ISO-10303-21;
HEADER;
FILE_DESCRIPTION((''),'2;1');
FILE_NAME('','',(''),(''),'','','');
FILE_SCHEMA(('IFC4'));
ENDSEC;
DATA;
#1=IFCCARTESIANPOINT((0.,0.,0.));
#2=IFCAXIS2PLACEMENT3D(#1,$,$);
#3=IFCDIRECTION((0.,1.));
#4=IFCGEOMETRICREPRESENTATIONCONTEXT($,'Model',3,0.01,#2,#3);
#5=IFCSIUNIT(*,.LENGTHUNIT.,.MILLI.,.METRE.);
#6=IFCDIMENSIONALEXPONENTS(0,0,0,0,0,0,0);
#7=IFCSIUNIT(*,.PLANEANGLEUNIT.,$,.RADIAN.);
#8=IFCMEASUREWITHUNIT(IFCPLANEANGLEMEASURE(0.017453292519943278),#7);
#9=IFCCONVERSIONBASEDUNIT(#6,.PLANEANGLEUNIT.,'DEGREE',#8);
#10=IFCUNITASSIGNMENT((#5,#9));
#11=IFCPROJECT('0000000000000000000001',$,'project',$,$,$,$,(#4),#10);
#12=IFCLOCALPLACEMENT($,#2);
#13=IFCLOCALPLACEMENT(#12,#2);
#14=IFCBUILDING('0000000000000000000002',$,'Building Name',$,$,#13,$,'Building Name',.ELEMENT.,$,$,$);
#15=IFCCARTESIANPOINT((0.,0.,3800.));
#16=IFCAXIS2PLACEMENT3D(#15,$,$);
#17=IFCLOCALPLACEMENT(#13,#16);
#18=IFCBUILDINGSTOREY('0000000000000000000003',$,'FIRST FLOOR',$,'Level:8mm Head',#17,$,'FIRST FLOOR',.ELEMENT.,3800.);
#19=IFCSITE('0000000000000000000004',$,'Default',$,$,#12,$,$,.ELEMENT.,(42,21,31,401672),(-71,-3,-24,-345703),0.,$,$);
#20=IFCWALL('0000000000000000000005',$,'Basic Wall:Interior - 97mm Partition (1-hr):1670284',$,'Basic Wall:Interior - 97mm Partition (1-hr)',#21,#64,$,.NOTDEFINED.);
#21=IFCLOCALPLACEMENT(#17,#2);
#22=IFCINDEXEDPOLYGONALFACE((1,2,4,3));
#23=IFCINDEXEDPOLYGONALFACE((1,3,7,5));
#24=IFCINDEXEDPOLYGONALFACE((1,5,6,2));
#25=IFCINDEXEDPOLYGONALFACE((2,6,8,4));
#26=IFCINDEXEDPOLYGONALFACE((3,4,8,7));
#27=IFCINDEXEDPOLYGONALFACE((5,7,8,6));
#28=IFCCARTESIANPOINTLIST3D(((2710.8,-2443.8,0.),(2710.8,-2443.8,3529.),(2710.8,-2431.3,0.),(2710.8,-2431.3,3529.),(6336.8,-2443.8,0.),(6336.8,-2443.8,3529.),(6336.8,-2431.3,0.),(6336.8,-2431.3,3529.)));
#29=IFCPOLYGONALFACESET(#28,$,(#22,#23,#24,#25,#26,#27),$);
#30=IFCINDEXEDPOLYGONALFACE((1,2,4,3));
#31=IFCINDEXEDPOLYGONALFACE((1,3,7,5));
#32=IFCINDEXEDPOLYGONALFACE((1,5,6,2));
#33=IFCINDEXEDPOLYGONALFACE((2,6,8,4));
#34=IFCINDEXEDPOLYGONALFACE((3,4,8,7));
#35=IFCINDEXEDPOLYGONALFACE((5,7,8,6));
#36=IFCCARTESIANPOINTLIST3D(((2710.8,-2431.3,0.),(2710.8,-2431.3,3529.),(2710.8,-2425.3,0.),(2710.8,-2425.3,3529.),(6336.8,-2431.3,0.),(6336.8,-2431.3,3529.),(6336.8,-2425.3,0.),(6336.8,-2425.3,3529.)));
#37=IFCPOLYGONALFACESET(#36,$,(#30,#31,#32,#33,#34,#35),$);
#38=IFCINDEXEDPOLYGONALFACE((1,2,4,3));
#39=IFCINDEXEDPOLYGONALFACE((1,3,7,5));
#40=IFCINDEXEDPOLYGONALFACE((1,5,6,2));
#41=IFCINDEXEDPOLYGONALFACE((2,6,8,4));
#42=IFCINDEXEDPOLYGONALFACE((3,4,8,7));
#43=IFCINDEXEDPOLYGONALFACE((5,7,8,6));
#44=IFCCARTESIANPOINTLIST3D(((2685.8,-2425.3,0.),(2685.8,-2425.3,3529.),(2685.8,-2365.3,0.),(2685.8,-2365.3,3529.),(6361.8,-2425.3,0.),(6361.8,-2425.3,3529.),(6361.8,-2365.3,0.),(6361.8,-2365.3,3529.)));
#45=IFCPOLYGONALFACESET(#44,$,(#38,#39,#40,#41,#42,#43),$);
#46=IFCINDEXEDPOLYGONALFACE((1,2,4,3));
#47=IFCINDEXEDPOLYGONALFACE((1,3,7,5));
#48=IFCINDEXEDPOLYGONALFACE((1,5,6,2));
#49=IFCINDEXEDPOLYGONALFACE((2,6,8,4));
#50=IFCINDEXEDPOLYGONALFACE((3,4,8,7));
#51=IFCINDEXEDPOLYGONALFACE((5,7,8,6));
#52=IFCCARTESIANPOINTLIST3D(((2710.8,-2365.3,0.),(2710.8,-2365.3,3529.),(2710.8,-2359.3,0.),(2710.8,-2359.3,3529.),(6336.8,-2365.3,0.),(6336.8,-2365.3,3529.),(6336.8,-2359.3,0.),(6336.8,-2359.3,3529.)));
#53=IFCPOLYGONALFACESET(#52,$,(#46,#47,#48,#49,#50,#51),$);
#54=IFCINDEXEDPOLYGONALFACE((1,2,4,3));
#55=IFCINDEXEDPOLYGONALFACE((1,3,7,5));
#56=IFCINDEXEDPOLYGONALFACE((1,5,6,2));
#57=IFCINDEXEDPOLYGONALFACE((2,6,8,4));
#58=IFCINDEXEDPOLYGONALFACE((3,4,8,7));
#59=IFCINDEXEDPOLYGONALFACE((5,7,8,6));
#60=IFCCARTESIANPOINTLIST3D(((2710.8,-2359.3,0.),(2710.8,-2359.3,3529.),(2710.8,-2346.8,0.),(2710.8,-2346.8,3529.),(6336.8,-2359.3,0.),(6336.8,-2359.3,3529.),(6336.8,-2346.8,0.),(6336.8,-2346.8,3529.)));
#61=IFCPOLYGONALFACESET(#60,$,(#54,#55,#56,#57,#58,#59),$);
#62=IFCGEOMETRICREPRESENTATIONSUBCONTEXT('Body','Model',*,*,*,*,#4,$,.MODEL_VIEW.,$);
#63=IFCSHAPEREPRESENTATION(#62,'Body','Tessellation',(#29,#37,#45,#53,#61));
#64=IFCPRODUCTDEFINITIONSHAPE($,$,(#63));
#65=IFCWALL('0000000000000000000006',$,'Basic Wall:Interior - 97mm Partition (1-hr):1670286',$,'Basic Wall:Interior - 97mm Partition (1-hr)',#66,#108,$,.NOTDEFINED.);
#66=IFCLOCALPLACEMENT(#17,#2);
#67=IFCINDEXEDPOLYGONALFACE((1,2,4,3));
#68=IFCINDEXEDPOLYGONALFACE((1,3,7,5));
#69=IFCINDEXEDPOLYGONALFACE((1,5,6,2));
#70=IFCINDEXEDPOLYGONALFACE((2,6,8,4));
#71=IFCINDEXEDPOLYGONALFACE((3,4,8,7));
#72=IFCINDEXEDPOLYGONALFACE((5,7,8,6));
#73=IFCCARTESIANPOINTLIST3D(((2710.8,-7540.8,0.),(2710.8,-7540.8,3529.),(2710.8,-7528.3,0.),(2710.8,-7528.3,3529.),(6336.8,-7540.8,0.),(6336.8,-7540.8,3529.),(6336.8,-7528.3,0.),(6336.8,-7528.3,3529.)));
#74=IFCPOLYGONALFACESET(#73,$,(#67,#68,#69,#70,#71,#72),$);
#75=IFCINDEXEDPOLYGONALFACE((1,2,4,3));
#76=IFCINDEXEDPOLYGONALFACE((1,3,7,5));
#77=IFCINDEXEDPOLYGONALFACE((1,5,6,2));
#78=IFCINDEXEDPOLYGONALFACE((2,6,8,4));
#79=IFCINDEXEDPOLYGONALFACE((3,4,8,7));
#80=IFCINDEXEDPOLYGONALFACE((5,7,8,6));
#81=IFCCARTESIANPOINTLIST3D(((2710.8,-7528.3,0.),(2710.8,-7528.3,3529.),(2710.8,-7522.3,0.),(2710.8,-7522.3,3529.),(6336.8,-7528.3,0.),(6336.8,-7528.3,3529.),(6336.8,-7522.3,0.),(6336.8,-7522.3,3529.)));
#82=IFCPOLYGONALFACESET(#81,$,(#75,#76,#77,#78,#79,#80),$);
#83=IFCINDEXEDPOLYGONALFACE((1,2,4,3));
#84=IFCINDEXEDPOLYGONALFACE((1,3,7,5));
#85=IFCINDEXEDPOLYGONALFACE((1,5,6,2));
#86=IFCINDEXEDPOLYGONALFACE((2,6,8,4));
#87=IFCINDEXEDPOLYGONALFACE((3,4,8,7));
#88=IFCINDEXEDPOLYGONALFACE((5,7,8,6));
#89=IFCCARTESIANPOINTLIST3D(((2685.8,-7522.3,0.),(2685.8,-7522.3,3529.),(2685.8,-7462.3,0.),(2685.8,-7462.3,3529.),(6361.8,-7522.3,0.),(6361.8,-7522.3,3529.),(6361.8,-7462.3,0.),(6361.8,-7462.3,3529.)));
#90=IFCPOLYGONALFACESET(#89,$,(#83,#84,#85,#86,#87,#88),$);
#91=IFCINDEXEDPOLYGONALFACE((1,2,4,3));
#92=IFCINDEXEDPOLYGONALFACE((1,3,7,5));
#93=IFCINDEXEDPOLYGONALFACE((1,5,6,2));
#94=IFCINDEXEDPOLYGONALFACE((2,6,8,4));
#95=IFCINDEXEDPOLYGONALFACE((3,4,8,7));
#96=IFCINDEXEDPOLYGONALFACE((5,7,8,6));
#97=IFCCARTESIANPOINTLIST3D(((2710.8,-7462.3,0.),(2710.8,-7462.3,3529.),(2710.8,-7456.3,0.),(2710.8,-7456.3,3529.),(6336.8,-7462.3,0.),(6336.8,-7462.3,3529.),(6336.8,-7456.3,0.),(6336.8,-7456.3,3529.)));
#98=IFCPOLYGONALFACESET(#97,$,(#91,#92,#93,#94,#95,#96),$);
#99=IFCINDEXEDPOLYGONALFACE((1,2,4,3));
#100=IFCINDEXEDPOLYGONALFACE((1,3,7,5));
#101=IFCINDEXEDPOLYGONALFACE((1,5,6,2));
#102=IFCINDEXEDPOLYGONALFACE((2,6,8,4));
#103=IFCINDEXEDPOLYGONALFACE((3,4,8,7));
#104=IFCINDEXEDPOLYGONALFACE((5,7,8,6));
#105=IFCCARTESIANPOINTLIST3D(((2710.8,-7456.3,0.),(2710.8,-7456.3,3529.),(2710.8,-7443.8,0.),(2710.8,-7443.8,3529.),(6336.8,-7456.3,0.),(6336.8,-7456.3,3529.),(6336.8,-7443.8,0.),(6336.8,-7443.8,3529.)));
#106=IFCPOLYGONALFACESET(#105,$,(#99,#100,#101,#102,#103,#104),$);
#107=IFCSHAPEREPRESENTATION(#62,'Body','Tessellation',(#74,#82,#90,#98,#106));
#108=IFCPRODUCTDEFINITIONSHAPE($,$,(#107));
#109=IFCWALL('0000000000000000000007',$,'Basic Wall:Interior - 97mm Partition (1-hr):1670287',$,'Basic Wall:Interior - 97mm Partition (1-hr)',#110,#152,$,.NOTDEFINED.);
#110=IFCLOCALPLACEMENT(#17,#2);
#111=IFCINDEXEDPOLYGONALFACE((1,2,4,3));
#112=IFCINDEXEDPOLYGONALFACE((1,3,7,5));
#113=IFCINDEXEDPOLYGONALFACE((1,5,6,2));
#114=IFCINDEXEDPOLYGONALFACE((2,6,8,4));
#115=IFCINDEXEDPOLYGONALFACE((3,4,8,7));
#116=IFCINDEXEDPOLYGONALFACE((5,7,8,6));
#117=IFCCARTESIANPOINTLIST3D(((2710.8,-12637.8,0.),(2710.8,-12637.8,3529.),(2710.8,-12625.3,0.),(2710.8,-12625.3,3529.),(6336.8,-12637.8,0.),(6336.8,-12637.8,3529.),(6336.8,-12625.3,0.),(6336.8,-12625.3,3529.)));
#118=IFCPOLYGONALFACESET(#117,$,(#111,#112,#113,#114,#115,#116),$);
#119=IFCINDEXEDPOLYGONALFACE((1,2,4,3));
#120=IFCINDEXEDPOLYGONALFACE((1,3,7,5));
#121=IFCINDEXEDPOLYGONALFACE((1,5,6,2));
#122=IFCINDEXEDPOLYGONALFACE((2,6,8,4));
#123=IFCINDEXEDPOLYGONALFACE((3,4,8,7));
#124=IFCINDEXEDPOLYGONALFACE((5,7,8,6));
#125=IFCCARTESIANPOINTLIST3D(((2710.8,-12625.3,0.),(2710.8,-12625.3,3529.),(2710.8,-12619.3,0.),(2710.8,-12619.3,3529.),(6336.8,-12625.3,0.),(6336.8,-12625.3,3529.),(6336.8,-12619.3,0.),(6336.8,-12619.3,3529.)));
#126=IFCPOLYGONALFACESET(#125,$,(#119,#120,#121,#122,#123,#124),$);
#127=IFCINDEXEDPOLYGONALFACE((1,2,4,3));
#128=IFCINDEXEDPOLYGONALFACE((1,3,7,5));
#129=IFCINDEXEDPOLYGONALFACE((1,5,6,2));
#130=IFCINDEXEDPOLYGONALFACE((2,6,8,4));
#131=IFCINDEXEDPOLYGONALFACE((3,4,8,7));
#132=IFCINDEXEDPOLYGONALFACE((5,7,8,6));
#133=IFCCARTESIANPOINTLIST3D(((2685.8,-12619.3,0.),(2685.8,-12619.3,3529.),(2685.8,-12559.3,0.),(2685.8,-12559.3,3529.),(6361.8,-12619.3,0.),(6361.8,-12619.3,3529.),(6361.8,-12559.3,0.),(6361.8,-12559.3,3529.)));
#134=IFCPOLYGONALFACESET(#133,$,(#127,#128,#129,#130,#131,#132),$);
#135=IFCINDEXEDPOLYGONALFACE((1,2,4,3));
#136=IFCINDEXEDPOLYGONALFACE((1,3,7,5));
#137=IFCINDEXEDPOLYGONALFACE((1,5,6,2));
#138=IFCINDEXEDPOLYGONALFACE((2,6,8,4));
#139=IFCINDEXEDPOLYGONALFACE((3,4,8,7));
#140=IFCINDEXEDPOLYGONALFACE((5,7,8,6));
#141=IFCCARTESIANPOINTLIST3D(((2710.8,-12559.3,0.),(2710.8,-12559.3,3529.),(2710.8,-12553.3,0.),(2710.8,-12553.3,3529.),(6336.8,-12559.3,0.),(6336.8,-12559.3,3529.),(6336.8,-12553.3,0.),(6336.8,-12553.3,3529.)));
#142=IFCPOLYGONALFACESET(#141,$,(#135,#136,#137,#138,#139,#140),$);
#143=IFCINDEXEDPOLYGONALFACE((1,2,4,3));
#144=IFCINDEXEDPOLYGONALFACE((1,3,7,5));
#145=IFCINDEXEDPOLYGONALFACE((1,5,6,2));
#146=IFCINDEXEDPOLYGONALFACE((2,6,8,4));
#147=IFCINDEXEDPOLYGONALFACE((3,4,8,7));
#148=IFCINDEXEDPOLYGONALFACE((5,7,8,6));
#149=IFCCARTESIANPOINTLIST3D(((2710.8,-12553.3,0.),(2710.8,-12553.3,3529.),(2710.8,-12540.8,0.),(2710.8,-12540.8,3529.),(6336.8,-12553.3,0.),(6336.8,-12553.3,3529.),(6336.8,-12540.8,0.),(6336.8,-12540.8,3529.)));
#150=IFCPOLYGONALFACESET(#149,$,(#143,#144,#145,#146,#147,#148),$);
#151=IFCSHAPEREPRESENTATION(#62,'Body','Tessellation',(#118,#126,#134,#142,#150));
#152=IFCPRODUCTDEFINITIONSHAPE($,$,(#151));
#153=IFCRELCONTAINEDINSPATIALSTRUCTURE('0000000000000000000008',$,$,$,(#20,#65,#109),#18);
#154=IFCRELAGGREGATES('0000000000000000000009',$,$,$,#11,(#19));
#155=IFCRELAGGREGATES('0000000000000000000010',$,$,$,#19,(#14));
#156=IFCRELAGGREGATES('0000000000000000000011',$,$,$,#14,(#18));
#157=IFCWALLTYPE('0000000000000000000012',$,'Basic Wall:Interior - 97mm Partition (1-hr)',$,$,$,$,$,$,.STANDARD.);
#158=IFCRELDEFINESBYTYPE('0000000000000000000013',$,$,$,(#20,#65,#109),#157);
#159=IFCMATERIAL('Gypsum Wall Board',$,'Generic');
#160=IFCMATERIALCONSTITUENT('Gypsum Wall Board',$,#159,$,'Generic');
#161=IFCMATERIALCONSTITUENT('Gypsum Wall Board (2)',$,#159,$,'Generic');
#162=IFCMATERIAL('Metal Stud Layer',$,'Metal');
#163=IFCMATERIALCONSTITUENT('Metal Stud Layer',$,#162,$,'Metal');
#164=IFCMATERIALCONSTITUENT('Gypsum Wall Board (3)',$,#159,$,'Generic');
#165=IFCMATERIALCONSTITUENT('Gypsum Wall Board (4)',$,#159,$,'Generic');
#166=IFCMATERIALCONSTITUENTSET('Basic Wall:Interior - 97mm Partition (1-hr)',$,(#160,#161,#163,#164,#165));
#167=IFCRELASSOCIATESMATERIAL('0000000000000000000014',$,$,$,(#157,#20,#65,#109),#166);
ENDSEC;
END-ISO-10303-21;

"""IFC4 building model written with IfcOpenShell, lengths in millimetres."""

from ifc_helpers import new_model, entity, si_unit, converted_unit, direction, frame, origin, place, context, subcontext, project, spatial, indexed_curve, outline, extrude, material, constituent, constituent_set, type_object, element, save


model = new_model("IFC4")

# Units and contexts
model_context = context("Model", 3, precision=0.01, world=origin(), true_north=direction((0.0, 1.0)))
body_context = subcontext(model_context, "Body", "Model", "MODEL_VIEW")
ifc_project = project(units=[si_unit("LENGTHUNIT", "METRE", prefix="MILLI"), converted_unit("PLANEANGLEUNIT", "DEGREE", entity("IfcPlaneAngleMeasure", 0.017453292519943278), si_unit("PLANEANGLEUNIT", "RADIAN"), dimensions=[0, 0, 0, 0, 0, 0, 0])], contexts=[model_context])

# Site, building, storey
site_placement = place(None, origin())
site = spatial("IfcSite", under=ifc_project, at=site_placement, Name="Default", CompositionType="ELEMENT", RefLatitude=(42, 21, 31, 401672), RefLongitude=(-71, -3, -24, -345703), RefElevation=0.0)
building_placement = place(site_placement, origin())
building = spatial("IfcBuilding", under=site, at=building_placement, Name="Building Name", LongName="Building Name", CompositionType="ELEMENT")
storey_placement = place(building_placement, frame((0.0, 0.0, 3800.0)))
storey = spatial("IfcBuildingStorey", under=building, at=storey_placement, Name="FIRST FLOOR", ObjectType="Level:8mm Head", LongName="FIRST FLOOR", CompositionType="ELEMENT", Elevation=3800.0)

# Walls
ifc_material_1 = material(Name="Gypsum Wall Board", Category="Generic")
ifc_constituent_1 = constituent(ifc_material_1, Name="Gypsum Wall Board", Category="Generic")
ifc_constituent_2 = constituent(ifc_material_1, Name="Gypsum Wall Board (2)", Category="Generic")
ifc_material_2 = material(Name="Metal Stud Layer", Category="Metal")
ifc_constituent_3 = constituent(ifc_material_2, Name="Metal Stud Layer", Category="Metal")
ifc_constituent_4 = constituent(ifc_material_1, Name="Gypsum Wall Board (3)", Category="Generic")
ifc_constituent_5 = constituent(ifc_material_1, Name="Gypsum Wall Board (4)", Category="Generic")
ifc_constituent_set_1 = constituent_set(constituents=[ifc_constituent_1, ifc_constituent_2, ifc_constituent_3, ifc_constituent_4, ifc_constituent_5], Name="Basic Wall:Interior - 97mm Partition (1-hr)")
wall_type_1 = type_object("IfcWallType", Name="Basic Wall:Interior - 97mm Partition (1-hr)", PredefinedType="STANDARD", material=ifc_constituent_set_1)
wall_1_placement = place(storey_placement, frame((6336.8, -2395.3, 0.0), z_axis=(0.0, 0.0, 1.0), x_axis=(-1.0, 0.0, 0.0)))
element("IfcWall", 1, at=wall_1_placement, inside=storey, type_object=wall_type_1, material=ifc_constituent_set_1, Name="Basic Wall:Interior - 97mm Partition (1-hr):1670284", ObjectType="Basic Wall:Interior - 97mm Partition (1-hr)", PredefinedType="NOTDEFINED", context=body_context, shape_type="SweptSolid", body=[
    extrude(outline(indexed_curve([(-6.2, -1764.5), (6.3, -1764.5), (6.2, 1764.5), (-6.2, 1764.5), (-6.2, -1764.5)], self_intersect=False)), frame((3626.0, 42.3, 1764.5), z_axis=(-1.0, 0.0, 0.0), x_axis=(0.0, -1.0, 0.0)), (0.0, 0.0, 1.0), 3626.0),
    extrude(outline(indexed_curve([(-1764.5, -3.0), (1764.5, -3.0), (1764.5, 3.0), (-1764.5, 3.0), (-1764.5, -3.0)], self_intersect=False)), frame((3626.0, 33.0, 1764.5), z_axis=(-1.0, 0.0, 0.0), x_axis=(0.0, 0.0, 1.0)), (0.0, 0.0, 1.0), 3626.0),
    extrude(outline(indexed_curve([(-1764.5, -30.0), (1764.5, -30.0), (1764.5, 30.0), (-1764.5, 30.0), (-1764.5, -30.0)], self_intersect=False)), frame((3651.0, 0.0, 1764.5), z_axis=(-1.0, 0.0, 0.0), x_axis=(0.0, 0.0, 1.0)), (0.0, 0.0, 1.0), 3676.0),
    extrude(outline(indexed_curve([(-1764.5, -3.0), (1764.5, -3.0), (1764.5, 3.0), (-1764.5, 3.0), (-1764.5, -3.0)], self_intersect=False)), frame((3626.0, -33.0, 1764.5), z_axis=(-1.0, 0.0, 0.0), x_axis=(0.0, 0.0, 1.0)), (0.0, 0.0, 1.0), 3626.0),
    extrude(outline(indexed_curve([(-6.3, -1764.5), (6.3, -1764.5), (6.3, 1764.5), (-6.3, 1764.5), (-6.3, -1764.5)], self_intersect=False)), frame((3626.0, -42.3, 1764.5), z_axis=(-1.0, 0.0, 0.0), x_axis=(0.0, 1.0, 0.0)), (0.0, 0.0, 1.0), 3626.0),
])
wall_2_placement = place(storey_placement, frame((6336.8, -7492.3, 0.0), z_axis=(0.0, 0.0, 1.0), x_axis=(-1.0, 0.0, 0.0)))
element("IfcWall", 2, at=wall_2_placement, inside=storey, type_object=wall_type_1, material=ifc_constituent_set_1, Name="Basic Wall:Interior - 97mm Partition (1-hr):1670286", ObjectType="Basic Wall:Interior - 97mm Partition (1-hr)", PredefinedType="NOTDEFINED", context=body_context, shape_type="SweptSolid", body=[
    extrude(outline(indexed_curve([(-6.2, -1764.5), (6.2, -1764.5), (6.3, 1764.5), (-6.2, 1764.5), (-6.2, -1764.5)], self_intersect=False)), frame((3626.0, 42.3, 1764.5), z_axis=(-1.0, 0.0, 0.0), x_axis=(0.0, -1.0, 0.0)), (0.0, 0.0, 1.0), 3626.0),
    extrude(outline(indexed_curve([(-1764.5, -3.0), (1764.5, -3.0), (1764.5, 3.0), (-1764.5, 3.0), (-1764.5, -3.0)], self_intersect=False)), frame((3626.0, 33.0, 1764.5), z_axis=(-1.0, 0.0, 0.0), x_axis=(0.0, 0.0, 1.0)), (0.0, 0.0, 1.0), 3626.0),
    extrude(outline(indexed_curve([(-1764.5, -30.0), (1764.5, -30.0), (1764.5, 30.0), (-1764.5, 30.0), (-1764.5, -30.0)], self_intersect=False)), frame((3651.0, 0.0, 1764.5), z_axis=(-1.0, 0.0, 0.0), x_axis=(0.0, 0.0, 1.0)), (0.0, 0.0, 1.0), 3676.0),
    extrude(outline(indexed_curve([(-1764.5, -3.0), (1764.5, -3.0), (1764.5, 3.0), (-1764.5, 3.0), (-1764.5, -3.0)], self_intersect=False)), frame((3626.0, -33.0, 1764.5), z_axis=(-1.0, 0.0, 0.0), x_axis=(0.0, 0.0, 1.0)), (0.0, 0.0, 1.0), 3626.0),
    extrude(outline(indexed_curve([(-6.2, -1764.5), (6.2, -1764.5), (6.2, 1764.5), (-6.2, 1764.5), (-6.2, -1764.5)], self_intersect=False)), frame((3626.0, -42.3, 1764.5), z_axis=(-1.0, 0.0, 0.0), x_axis=(0.0, 1.0, 0.0)), (0.0, 0.0, 1.0), 3626.0),
])
wall_3_placement = place(storey_placement, frame((6336.8, -12589.3, 0.0), z_axis=(0.0, 0.0, 1.0), x_axis=(-1.0, 0.0, 0.0)))
element("IfcWall", 3, at=wall_3_placement, inside=storey, type_object=wall_type_1, material=ifc_constituent_set_1, Name="Basic Wall:Interior - 97mm Partition (1-hr):1670287", ObjectType="Basic Wall:Interior - 97mm Partition (1-hr)", PredefinedType="NOTDEFINED", context=body_context, shape_type="SweptSolid", body=[
    extrude(outline(indexed_curve([(-6.2, -1764.5), (6.3, -1764.5), (6.2, 1764.5), (-6.2, 1764.5), (-6.2, -1764.5)], self_intersect=False)), frame((3626.0, 42.2, 1764.5), z_axis=(-1.0, 0.0, 0.0), x_axis=(0.0, -1.0, 0.0)), (0.0, 0.0, 1.0), 3626.0),
    extrude(outline(indexed_curve([(-1764.5, -3.0), (1764.5, -3.0), (1764.5, 3.0), (-1764.5, 3.0), (-1764.5, -3.0)], self_intersect=False)), frame((3626.0, 33.0, 1764.5), z_axis=(-1.0, 0.0, 0.0), x_axis=(0.0, 0.0, 1.0)), (0.0, 0.0, 1.0), 3626.0),
    extrude(outline(indexed_curve([(-1764.5, -30.0), (1764.5, -30.0), (1764.5, 30.0), (-1764.5, 30.0), (-1764.5, -30.0)], self_intersect=False)), frame((3651.0, 0.0, 1764.5), z_axis=(-1.0, 0.0, 0.0), x_axis=(0.0, 0.0, 1.0)), (0.0, 0.0, 1.0), 3676.0),
    extrude(outline(indexed_curve([(-1764.5, -3.0), (1764.5, -3.0), (1764.5, 3.0), (-1764.5, 3.0), (-1764.5, -3.0)], self_intersect=False)), frame((3626.0, -33.0, 1764.5), z_axis=(-1.0, 0.0, 0.0), x_axis=(0.0, 0.0, 1.0)), (0.0, 0.0, 1.0), 3626.0),
    extrude(outline(indexed_curve([(-6.3, -1764.5), (6.2, -1764.5), (6.2, 1764.5), (-6.3, 1764.5), (-6.3, -1764.5)], self_intersect=False)), frame((3626.0, -42.3, 1764.5), z_axis=(-1.0, 0.0, 0.0), x_axis=(0.0, 1.0, 0.0)), (0.0, 0.0, 1.0), 3626.0),
])

save(model, "model.ifc")
